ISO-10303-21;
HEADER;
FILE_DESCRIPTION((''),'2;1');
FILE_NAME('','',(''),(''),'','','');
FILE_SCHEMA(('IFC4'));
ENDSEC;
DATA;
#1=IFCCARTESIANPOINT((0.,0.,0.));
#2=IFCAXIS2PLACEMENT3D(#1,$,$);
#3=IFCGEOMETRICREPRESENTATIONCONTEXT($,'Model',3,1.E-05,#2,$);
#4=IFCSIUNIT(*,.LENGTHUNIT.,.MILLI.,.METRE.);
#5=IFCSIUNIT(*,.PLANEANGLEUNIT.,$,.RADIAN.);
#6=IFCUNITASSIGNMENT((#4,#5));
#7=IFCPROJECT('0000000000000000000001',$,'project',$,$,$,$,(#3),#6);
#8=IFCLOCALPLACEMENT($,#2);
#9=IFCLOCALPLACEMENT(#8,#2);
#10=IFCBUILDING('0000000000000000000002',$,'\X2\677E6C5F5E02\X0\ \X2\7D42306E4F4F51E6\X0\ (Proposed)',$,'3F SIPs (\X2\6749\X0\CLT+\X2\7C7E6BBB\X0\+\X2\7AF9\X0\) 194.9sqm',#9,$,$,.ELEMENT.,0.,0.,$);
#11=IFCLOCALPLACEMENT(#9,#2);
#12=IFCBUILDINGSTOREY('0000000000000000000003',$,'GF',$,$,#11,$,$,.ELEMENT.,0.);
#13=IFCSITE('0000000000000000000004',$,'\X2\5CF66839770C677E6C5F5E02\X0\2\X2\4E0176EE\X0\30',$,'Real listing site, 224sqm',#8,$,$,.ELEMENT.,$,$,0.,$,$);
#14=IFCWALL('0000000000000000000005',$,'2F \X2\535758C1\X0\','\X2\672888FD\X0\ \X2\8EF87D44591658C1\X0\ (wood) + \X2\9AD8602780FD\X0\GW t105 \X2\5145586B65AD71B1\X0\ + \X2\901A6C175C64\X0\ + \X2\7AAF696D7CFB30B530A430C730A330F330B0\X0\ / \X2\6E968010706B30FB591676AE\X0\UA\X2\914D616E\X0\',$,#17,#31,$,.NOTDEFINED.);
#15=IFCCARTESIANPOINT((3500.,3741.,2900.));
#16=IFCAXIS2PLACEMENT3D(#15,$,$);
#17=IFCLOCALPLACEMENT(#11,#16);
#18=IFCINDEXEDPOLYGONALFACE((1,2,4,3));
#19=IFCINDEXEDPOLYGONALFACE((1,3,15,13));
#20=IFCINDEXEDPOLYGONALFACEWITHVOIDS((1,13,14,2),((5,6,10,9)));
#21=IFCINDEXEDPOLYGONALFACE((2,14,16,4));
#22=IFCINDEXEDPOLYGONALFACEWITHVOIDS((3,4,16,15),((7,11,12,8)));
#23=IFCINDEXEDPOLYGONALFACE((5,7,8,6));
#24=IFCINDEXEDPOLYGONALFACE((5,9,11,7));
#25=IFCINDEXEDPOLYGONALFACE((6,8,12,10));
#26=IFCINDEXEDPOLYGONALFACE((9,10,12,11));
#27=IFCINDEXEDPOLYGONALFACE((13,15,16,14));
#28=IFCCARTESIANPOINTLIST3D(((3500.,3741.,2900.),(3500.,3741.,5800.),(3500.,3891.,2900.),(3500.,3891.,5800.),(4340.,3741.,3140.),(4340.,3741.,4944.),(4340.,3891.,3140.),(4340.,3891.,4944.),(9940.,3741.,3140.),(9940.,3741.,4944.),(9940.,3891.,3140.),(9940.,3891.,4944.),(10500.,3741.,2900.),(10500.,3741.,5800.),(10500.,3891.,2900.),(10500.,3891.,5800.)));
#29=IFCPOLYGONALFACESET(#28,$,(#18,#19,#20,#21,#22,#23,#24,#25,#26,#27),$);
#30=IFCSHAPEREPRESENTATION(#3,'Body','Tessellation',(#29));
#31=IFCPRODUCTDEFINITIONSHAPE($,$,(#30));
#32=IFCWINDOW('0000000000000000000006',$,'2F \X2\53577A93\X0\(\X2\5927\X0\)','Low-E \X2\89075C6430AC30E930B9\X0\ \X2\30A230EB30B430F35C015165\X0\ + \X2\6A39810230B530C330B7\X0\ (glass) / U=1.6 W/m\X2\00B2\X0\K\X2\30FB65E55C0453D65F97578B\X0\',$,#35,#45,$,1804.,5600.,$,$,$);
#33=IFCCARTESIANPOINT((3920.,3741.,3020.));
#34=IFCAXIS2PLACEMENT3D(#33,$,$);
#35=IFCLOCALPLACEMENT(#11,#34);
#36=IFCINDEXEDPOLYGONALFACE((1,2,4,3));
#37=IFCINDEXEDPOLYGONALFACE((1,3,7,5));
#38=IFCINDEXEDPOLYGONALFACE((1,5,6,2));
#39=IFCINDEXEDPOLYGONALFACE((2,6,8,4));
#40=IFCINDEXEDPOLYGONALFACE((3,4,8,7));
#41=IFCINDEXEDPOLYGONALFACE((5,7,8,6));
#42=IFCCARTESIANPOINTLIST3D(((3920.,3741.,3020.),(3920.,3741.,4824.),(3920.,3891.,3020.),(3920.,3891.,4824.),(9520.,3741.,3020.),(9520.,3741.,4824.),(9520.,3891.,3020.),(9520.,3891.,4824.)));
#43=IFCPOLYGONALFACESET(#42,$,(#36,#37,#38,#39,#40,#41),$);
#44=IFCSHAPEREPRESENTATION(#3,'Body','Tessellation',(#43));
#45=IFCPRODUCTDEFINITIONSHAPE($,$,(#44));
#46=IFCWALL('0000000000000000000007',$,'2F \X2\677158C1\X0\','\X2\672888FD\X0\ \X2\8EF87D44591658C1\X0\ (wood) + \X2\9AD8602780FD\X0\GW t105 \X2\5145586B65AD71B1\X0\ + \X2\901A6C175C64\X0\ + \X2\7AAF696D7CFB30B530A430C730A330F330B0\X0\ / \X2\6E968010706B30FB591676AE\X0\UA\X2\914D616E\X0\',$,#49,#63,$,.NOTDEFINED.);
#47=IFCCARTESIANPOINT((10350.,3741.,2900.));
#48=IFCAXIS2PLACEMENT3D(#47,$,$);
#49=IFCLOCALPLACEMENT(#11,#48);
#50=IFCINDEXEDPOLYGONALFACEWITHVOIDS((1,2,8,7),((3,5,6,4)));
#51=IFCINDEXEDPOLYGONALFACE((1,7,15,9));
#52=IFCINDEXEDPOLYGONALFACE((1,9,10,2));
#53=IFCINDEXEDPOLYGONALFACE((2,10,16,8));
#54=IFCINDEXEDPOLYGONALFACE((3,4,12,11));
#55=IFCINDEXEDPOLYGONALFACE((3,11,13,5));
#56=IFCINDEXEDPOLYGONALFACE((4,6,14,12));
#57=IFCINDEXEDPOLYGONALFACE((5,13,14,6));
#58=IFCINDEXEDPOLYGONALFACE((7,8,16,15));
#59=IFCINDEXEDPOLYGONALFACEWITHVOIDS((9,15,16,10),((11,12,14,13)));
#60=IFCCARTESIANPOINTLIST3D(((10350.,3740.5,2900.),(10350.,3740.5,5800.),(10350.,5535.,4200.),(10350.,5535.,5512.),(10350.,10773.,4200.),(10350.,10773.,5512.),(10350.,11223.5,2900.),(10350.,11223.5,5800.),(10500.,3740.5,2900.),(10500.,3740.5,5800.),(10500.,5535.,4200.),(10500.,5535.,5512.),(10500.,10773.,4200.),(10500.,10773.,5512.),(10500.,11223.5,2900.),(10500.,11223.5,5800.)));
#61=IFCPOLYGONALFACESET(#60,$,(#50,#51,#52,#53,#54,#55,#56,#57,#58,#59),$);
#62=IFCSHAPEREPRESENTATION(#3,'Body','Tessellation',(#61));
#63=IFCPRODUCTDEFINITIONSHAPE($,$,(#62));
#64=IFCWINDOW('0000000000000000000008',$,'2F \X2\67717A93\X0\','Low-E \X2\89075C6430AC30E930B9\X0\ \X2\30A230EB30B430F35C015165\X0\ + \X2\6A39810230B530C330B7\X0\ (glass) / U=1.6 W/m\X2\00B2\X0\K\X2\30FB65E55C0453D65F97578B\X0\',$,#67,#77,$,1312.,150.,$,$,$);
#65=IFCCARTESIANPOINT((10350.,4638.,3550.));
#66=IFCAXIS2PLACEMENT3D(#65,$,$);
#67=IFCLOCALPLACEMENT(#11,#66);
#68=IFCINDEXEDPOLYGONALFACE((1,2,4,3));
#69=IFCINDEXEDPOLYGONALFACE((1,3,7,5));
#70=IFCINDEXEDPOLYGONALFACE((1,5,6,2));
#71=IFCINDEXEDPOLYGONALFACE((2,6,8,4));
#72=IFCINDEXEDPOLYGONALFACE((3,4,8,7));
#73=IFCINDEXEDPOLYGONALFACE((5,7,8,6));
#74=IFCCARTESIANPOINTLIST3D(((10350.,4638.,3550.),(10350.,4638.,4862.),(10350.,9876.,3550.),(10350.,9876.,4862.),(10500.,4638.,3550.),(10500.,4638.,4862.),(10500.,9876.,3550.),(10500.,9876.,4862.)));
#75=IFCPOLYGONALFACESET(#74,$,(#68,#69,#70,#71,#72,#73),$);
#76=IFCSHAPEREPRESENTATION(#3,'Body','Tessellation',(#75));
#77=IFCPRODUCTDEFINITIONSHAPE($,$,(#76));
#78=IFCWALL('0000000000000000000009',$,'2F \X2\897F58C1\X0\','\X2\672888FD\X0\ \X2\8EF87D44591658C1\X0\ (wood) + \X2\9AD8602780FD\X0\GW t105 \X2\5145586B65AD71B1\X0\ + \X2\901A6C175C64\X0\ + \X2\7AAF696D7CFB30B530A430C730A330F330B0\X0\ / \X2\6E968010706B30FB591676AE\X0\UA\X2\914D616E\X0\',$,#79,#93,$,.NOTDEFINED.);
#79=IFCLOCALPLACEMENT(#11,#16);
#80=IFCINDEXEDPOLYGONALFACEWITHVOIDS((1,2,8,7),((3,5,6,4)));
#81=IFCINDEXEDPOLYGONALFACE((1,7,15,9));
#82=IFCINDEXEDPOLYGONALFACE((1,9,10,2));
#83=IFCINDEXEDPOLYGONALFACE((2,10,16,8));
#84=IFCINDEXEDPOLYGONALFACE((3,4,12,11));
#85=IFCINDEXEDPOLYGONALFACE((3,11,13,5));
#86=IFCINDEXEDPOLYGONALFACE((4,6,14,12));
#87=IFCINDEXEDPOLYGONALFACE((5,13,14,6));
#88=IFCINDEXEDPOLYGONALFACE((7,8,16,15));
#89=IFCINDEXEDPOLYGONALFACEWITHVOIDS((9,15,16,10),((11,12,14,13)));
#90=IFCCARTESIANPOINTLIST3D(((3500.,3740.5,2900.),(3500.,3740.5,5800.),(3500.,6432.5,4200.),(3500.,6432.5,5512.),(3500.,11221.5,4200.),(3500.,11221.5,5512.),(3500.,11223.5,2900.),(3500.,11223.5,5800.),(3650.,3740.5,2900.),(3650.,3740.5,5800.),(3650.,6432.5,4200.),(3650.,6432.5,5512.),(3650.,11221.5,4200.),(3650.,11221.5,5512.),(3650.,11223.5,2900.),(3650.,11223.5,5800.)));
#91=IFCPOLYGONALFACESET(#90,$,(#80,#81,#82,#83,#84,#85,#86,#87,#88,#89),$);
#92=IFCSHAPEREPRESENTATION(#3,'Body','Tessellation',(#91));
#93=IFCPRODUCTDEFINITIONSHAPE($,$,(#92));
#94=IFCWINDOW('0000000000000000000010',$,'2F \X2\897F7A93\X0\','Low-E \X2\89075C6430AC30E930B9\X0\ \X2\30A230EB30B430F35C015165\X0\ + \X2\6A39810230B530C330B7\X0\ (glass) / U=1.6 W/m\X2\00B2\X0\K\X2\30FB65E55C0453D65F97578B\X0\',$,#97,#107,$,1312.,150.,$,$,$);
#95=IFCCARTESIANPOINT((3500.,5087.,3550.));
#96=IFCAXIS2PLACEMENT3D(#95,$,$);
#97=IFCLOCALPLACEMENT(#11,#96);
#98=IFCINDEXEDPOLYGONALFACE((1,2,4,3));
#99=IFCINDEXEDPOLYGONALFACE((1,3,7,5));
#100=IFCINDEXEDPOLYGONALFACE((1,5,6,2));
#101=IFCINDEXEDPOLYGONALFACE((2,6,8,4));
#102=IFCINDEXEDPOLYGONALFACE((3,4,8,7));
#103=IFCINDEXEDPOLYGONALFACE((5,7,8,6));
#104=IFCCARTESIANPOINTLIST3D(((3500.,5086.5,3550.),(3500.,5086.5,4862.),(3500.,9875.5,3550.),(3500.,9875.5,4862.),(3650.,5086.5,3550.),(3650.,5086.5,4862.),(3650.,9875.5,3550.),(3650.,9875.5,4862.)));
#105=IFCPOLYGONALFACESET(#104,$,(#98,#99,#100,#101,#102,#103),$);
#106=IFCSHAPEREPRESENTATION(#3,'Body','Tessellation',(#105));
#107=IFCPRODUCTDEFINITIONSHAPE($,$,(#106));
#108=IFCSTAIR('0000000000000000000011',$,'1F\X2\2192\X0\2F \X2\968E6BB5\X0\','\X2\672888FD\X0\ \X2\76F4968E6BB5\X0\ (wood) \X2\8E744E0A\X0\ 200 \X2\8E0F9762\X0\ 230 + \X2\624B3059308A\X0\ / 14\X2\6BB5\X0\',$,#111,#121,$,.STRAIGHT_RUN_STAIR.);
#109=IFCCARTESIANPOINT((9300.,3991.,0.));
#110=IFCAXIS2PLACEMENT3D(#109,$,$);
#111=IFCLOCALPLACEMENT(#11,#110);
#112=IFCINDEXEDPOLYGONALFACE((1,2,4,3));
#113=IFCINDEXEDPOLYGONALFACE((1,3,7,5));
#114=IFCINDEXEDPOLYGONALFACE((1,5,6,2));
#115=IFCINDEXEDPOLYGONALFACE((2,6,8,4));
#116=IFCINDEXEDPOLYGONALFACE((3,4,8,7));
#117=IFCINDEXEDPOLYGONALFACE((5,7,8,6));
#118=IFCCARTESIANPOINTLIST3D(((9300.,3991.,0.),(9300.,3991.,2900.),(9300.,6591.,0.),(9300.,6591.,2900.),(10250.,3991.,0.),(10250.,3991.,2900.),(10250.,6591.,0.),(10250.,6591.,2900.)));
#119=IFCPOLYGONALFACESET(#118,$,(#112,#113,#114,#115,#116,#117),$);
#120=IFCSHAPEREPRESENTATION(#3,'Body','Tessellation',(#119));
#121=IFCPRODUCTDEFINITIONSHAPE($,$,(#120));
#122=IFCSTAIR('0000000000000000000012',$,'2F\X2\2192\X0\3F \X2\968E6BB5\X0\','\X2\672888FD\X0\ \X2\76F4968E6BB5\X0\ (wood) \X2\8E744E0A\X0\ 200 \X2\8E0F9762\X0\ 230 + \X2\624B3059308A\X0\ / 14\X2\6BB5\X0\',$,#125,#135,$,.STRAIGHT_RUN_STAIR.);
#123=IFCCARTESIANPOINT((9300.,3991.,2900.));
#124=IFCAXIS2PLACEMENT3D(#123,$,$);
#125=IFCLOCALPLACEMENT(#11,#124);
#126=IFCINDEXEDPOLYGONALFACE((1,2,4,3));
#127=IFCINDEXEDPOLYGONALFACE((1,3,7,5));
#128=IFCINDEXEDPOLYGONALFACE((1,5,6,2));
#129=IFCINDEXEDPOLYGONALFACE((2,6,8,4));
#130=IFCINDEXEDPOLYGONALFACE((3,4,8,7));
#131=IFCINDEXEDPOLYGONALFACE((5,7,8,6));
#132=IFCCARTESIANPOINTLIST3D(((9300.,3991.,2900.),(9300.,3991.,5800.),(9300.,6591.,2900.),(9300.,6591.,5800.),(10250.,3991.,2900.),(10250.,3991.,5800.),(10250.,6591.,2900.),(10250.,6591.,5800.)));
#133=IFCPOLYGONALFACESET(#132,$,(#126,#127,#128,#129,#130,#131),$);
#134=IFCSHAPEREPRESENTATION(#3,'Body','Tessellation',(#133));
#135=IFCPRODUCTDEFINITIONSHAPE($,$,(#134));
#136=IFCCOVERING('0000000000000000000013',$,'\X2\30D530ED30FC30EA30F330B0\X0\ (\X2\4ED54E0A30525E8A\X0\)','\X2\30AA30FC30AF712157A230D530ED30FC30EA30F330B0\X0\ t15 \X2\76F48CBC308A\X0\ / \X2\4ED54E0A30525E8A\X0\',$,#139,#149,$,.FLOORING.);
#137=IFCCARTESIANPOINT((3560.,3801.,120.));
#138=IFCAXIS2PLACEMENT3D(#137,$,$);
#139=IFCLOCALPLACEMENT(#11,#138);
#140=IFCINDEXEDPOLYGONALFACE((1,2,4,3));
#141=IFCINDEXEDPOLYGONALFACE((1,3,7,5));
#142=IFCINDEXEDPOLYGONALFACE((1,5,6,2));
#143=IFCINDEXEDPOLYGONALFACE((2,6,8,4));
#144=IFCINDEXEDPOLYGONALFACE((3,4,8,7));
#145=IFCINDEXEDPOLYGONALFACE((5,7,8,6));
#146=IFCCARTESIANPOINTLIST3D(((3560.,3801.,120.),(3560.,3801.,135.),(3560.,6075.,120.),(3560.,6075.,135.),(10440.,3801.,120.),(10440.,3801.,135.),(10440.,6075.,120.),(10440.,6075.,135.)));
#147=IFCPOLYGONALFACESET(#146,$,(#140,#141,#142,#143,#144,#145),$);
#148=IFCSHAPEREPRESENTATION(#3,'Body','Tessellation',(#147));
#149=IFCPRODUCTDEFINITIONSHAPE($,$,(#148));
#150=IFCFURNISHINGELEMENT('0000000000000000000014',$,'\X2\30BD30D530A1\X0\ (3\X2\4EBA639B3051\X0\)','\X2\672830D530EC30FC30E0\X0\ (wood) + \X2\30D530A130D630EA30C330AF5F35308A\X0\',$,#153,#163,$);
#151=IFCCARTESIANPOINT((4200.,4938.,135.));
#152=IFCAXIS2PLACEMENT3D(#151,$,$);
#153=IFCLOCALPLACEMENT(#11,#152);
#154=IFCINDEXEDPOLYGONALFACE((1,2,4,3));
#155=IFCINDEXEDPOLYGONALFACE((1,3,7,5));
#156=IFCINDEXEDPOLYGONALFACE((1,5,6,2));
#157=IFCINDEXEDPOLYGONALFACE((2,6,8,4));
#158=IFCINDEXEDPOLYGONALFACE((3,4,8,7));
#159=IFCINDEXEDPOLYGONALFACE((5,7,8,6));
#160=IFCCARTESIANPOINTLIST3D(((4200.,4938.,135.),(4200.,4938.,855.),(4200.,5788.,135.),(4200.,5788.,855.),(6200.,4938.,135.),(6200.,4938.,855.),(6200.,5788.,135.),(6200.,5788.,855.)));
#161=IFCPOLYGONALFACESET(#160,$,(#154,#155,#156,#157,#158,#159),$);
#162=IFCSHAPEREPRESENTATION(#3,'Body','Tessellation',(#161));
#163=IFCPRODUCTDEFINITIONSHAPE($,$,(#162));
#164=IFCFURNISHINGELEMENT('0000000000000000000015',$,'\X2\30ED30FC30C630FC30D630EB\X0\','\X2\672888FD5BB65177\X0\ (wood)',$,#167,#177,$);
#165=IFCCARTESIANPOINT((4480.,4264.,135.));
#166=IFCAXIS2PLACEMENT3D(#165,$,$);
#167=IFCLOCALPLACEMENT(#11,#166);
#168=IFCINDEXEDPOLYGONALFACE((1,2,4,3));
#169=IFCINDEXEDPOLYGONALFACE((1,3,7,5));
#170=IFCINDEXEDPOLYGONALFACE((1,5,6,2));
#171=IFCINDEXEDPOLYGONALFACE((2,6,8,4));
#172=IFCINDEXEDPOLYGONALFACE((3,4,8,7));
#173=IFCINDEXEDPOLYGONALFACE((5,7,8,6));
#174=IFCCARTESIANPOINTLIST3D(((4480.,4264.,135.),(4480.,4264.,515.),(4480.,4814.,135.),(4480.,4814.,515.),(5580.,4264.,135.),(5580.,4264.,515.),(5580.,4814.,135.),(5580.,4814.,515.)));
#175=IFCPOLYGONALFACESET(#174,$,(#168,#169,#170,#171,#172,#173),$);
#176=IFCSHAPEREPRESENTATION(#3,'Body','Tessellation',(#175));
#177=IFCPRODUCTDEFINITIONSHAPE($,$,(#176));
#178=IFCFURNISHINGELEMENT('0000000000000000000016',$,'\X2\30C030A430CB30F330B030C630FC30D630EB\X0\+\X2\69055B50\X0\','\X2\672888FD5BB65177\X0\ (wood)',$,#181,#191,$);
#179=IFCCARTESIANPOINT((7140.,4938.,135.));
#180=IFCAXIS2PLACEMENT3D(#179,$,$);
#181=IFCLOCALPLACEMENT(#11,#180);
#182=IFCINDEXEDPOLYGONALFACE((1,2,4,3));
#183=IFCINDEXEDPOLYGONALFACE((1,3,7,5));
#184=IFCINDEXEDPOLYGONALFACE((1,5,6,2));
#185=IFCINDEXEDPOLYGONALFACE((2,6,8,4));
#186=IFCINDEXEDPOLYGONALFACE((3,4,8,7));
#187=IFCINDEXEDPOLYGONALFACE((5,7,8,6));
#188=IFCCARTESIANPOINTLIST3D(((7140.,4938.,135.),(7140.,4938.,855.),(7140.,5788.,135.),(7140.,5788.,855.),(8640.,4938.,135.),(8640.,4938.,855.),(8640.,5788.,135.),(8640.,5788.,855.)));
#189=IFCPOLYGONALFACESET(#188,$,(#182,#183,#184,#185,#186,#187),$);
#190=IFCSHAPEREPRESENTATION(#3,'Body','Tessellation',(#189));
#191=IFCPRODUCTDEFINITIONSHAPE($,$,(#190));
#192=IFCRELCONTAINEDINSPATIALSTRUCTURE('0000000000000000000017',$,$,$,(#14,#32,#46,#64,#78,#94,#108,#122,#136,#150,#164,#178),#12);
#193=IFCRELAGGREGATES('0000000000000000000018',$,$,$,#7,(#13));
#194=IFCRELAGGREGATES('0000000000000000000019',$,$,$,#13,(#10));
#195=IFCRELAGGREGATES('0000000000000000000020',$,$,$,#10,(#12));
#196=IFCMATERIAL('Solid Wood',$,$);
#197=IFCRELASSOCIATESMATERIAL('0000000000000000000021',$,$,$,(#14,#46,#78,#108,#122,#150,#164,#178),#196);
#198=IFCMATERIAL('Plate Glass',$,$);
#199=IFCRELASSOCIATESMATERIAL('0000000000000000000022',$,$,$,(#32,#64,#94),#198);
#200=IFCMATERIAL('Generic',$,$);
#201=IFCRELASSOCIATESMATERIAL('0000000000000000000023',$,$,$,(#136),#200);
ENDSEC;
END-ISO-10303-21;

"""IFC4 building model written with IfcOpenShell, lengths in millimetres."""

from ifc_helpers import new_model, si_unit, frame, frame_2d, origin, place, context, project, spatial, rectangle, extrude, material, element, fill, save


model = new_model("IFC4")

# Units and contexts
model_context = context("Model", 3, precision=1e-05, world=origin())
ifc_project = project(units=[si_unit("LENGTHUNIT", "METRE", prefix="MILLI"), si_unit("PLANEANGLEUNIT", "RADIAN")], contexts=[model_context])

# Site, building, storey
site_placement = place(None, origin())
site = spatial("IfcSite", under=ifc_project, at=site_placement, Name="島根県松江市2丁目30", ObjectType="Real listing site, 224sqm", CompositionType="ELEMENT", RefElevation=0.0)
building_placement = place(site_placement, origin())
building = spatial("IfcBuilding", under=site, at=building_placement, Name="松江市 終の住処 (Proposed)", ObjectType="3F SIPs (杉CLT+籾殻+竹) 194.9sqm", CompositionType="ELEMENT", ElevationOfRefHeight=0.0, ElevationOfTerrain=0.0)
storey_placement = place(building_placement, origin())
storey = spatial("IfcBuildingStorey", under=building, at=storey_placement, Name="GF", CompositionType="ELEMENT", Elevation=0.0)

# Shared definitions
ifc_material_1 = material(Name="Solid Wood")

# Shared definitions
ifc_material_2 = material(Name="Plate Glass")

# Walls, openings, windows
wall_1_placement = place(storey_placement, frame((3500.0, 3741.0, 2900.0)))
wall_1 = element("IfcWall", 1, at=wall_1_placement, inside=storey, material=ifc_material_1, Name="2F 南壁", Description="木製 軸組外壁 (wood) + 高性能GW t105 充填断熱 + 通気層 + 窯業系サイディング / 準耐火・外皮UA配慮", PredefinedType="NOTDEFINED", context=model_context, shape_type="SweptSolid", body=[
    extrude(rectangle(XDim=7000.0, YDim=150.0, at=frame_2d((3500.0, 75.0))), frame((3500.0, 3741.0, 2900.0)), (0.0, 0.0, 1.0), 2900.0),
])
opening_1_placement = place(storey_placement, frame((3920.0, 3741.0, 3020.0)))
opening_1 = element("IfcOpeningElement", 2, at=opening_1_placement, cuts=wall_1, PredefinedType="NOTDEFINED", context=model_context, shape_type="SweptSolid", body=[
    extrude(rectangle(XDim=5600.0, YDim=150.0, at=frame_2d((2800.0, 75.0))), frame((3920.0, 3741.0, 3020.0)), (0.0, 0.0, 1.0), 1804.0),
])
window_1_placement = place(storey_placement, frame((3920.0, 3741.0, 3020.0)))
window_1 = element("IfcWindow", 3, at=window_1_placement, inside=storey, material=ifc_material_2, Name="2F 南窓(大)", Description="Low-E 複層ガラス アルゴン封入 + 樹脂サッシ (glass) / U=1.6 W/m²K・日射取得型", OverallHeight=1804.0, OverallWidth=5600.0, context=model_context, shape_type="SweptSolid", body=[
    extrude(rectangle(XDim=5600.0, YDim=150.0, at=frame_2d((2800.0, 75.0))), frame((3920.0, 3741.0, 3020.0)), (0.0, 0.0, 1.0), 1804.0),
])
fill(opening_1, window_1)
wall_2_placement = place(storey_placement, frame((10350.0, 3741.0, 2900.0)))
wall_2 = element("IfcWall", 4, at=wall_2_placement, inside=storey, material=ifc_material_1, Name="2F 東壁", Description="木製 軸組外壁 (wood) + 高性能GW t105 充填断熱 + 通気層 + 窯業系サイディング / 準耐火・外皮UA配慮", PredefinedType="NOTDEFINED", context=model_context, shape_type="SweptSolid", body=[
    extrude(rectangle(XDim=150.0, YDim=7483.0, at=frame_2d((75.0, 3741.0))), frame((10350.0, 3741.0, 2900.0)), (0.0, 0.0, 1.0), 2900.0),
])
opening_2_placement = place(storey_placement, frame((10350.0, 4638.0, 3550.0)))
opening_2 = element("IfcOpeningElement", 5, at=opening_2_placement, cuts=wall_2, PredefinedType="NOTDEFINED", context=model_context, shape_type="SweptSolid", body=[
    extrude(rectangle(XDim=150.0, YDim=5238.0, at=frame_2d((75.0, 2619.0))), frame((10350.0, 4638.0, 3550.0)), (0.0, 0.0, 1.0), 1312.0),
])
window_2_placement = place(storey_placement, frame((10350.0, 4638.0, 3550.0)))
window_2 = element("IfcWindow", 6, at=window_2_placement, inside=storey, material=ifc_material_2, Name="2F 東窓", Description="Low-E 複層ガラス アルゴン封入 + 樹脂サッシ (glass) / U=1.6 W/m²K・日射取得型", OverallHeight=1312.0, OverallWidth=150.0, context=model_context, shape_type="SweptSolid", body=[
    extrude(rectangle(XDim=150.0, YDim=5238.0, at=frame_2d((75.0, 2619.0))), frame((10350.0, 4638.0, 3550.0)), (0.0, 0.0, 1.0), 1312.0),
])
fill(opening_2, window_2)
wall_3_placement = place(storey_placement, frame((3500.0, 3741.0, 2900.0)))
wall_3 = element("IfcWall", 7, at=wall_3_placement, inside=storey, material=ifc_material_1, Name="2F 西壁", Description="木製 軸組外壁 (wood) + 高性能GW t105 充填断熱 + 通気層 + 窯業系サイディング / 準耐火・外皮UA配慮", PredefinedType="NOTDEFINED", context=model_context, shape_type="SweptSolid", body=[
    extrude(rectangle(XDim=150.0, YDim=7483.0, at=frame_2d((75.0, 3741.0))), frame((3500.0, 3741.0, 2900.0)), (0.0, 0.0, 1.0), 2900.0),
])
opening_3_placement = place(storey_placement, frame((3500.0, 5087.0, 3550.0)))
opening_3 = element("IfcOpeningElement", 8, at=opening_3_placement, cuts=wall_3, PredefinedType="NOTDEFINED", context=model_context, shape_type="SweptSolid", body=[
    extrude(rectangle(XDim=150.0, YDim=4789.0, at=frame_2d((75.0, 2394.0))), frame((3500.0, 5087.0, 3550.0)), (0.0, 0.0, 1.0), 1312.0),
])
window_3_placement = place(storey_placement, frame((3500.0, 5087.0, 3550.0)))
window_3 = element("IfcWindow", 9, at=window_3_placement, inside=storey, material=ifc_material_2, Name="2F 西窓", Description="Low-E 複層ガラス アルゴン封入 + 樹脂サッシ (glass) / U=1.6 W/m²K・日射取得型", OverallHeight=1312.0, OverallWidth=150.0, context=model_context, shape_type="SweptSolid", body=[
    extrude(rectangle(XDim=150.0, YDim=4789.0, at=frame_2d((75.0, 2394.0))), frame((3500.0, 5087.0, 3550.0)), (0.0, 0.0, 1.0), 1312.0),
])
fill(opening_3, window_3)

# Stairs
stair_1_placement = place(storey_placement, frame((9300.0, 3991.0, 0.0)))
element("IfcStair", 10, at=stair_1_placement, inside=storey, material=ifc_material_1, Name="1F→2F 階段", Description="木製 直階段 (wood) 蹴上 200 踏面 230 + 手すり / 14段", PredefinedType="STRAIGHT_RUN_STAIR", context=model_context, shape_type="SweptSolid", body=[
    extrude(rectangle(XDim=950.0, YDim=2600.0, at=frame_2d((475.0, 1300.0))), frame((9300.0, 3991.0, 0.0)), (0.0, 0.0, 1.0), 2900.0),
])
stair_2_placement = place(storey_placement, frame((9300.0, 3991.0, 2900.0)))
element("IfcStair", 11, at=stair_2_placement, inside=storey, material=ifc_material_1, Name="2F→3F 階段", Description="木製 直階段 (wood) 蹴上 200 踏面 230 + 手すり / 14段", PredefinedType="STRAIGHT_RUN_STAIR", context=model_context, shape_type="SweptSolid", body=[
    extrude(rectangle(XDim=950.0, YDim=2600.0, at=frame_2d((475.0, 1300.0))), frame((9300.0, 3991.0, 2900.0)), (0.0, 0.0, 1.0), 2900.0),
])

# Covering
ifc_material_3 = material(Name="Generic")
covering_placement = place(storey_placement, frame((3560.0, 3801.0, 120.0)))
element("IfcCovering", 12, at=covering_placement, inside=storey, material=ifc_material_3, Name="フローリング (仕上げ床)", Description="オーク無垢フローリング t15 直貼り / 仕上げ床", PredefinedType="FLOORING", context=model_context, shape_type="SweptSolid", body=[
    extrude(rectangle(XDim=6880.0, YDim=2274.0, at=frame_2d((3440.0, 1137.0))), frame((3560.0, 3801.0, 120.0)), (0.0, 0.0, 1.0), 15.0),
])

# Furnishing elements
furnishing_1_placement = place(storey_placement, frame((4200.0, 4938.0, 135.0)))
element("IfcFurnishingElement", 13, at=furnishing_1_placement, inside=storey, material=ifc_material_1, Name="ソファ (3人掛け)", Description="木フレーム (wood) + ファブリック張り", context=model_context, shape_type="SweptSolid", body=[
    extrude(rectangle(XDim=2000.0, YDim=850.0, at=frame_2d((1000.0, 425.0))), frame((4200.0, 4938.0, 135.0)), (0.0, 0.0, 1.0), 720.0),
])
furnishing_2_placement = place(storey_placement, frame((4480.0, 4264.0, 135.0)))
element("IfcFurnishingElement", 14, at=furnishing_2_placement, inside=storey, material=ifc_material_1, Name="ローテーブル", Description="木製家具 (wood)", context=model_context, shape_type="SweptSolid", body=[
    extrude(rectangle(XDim=1100.0, YDim=550.0, at=frame_2d((550.0, 275.0))), frame((4480.0, 4264.0, 135.0)), (0.0, 0.0, 1.0), 380.0),
])
furnishing_3_placement = place(storey_placement, frame((7140.0, 4938.0, 135.0)))
element("IfcFurnishingElement", 15, at=furnishing_3_placement, inside=storey, material=ifc_material_1, Name="ダイニングテーブル+椅子", Description="木製家具 (wood)", context=model_context, shape_type="SweptSolid", body=[
    extrude(rectangle(XDim=1500.0, YDim=850.0, at=frame_2d((750.0, 425.0))), frame((7140.0, 4938.0, 135.0)), (0.0, 0.0, 1.0), 720.0),
])

save(model, "model.ifc")
